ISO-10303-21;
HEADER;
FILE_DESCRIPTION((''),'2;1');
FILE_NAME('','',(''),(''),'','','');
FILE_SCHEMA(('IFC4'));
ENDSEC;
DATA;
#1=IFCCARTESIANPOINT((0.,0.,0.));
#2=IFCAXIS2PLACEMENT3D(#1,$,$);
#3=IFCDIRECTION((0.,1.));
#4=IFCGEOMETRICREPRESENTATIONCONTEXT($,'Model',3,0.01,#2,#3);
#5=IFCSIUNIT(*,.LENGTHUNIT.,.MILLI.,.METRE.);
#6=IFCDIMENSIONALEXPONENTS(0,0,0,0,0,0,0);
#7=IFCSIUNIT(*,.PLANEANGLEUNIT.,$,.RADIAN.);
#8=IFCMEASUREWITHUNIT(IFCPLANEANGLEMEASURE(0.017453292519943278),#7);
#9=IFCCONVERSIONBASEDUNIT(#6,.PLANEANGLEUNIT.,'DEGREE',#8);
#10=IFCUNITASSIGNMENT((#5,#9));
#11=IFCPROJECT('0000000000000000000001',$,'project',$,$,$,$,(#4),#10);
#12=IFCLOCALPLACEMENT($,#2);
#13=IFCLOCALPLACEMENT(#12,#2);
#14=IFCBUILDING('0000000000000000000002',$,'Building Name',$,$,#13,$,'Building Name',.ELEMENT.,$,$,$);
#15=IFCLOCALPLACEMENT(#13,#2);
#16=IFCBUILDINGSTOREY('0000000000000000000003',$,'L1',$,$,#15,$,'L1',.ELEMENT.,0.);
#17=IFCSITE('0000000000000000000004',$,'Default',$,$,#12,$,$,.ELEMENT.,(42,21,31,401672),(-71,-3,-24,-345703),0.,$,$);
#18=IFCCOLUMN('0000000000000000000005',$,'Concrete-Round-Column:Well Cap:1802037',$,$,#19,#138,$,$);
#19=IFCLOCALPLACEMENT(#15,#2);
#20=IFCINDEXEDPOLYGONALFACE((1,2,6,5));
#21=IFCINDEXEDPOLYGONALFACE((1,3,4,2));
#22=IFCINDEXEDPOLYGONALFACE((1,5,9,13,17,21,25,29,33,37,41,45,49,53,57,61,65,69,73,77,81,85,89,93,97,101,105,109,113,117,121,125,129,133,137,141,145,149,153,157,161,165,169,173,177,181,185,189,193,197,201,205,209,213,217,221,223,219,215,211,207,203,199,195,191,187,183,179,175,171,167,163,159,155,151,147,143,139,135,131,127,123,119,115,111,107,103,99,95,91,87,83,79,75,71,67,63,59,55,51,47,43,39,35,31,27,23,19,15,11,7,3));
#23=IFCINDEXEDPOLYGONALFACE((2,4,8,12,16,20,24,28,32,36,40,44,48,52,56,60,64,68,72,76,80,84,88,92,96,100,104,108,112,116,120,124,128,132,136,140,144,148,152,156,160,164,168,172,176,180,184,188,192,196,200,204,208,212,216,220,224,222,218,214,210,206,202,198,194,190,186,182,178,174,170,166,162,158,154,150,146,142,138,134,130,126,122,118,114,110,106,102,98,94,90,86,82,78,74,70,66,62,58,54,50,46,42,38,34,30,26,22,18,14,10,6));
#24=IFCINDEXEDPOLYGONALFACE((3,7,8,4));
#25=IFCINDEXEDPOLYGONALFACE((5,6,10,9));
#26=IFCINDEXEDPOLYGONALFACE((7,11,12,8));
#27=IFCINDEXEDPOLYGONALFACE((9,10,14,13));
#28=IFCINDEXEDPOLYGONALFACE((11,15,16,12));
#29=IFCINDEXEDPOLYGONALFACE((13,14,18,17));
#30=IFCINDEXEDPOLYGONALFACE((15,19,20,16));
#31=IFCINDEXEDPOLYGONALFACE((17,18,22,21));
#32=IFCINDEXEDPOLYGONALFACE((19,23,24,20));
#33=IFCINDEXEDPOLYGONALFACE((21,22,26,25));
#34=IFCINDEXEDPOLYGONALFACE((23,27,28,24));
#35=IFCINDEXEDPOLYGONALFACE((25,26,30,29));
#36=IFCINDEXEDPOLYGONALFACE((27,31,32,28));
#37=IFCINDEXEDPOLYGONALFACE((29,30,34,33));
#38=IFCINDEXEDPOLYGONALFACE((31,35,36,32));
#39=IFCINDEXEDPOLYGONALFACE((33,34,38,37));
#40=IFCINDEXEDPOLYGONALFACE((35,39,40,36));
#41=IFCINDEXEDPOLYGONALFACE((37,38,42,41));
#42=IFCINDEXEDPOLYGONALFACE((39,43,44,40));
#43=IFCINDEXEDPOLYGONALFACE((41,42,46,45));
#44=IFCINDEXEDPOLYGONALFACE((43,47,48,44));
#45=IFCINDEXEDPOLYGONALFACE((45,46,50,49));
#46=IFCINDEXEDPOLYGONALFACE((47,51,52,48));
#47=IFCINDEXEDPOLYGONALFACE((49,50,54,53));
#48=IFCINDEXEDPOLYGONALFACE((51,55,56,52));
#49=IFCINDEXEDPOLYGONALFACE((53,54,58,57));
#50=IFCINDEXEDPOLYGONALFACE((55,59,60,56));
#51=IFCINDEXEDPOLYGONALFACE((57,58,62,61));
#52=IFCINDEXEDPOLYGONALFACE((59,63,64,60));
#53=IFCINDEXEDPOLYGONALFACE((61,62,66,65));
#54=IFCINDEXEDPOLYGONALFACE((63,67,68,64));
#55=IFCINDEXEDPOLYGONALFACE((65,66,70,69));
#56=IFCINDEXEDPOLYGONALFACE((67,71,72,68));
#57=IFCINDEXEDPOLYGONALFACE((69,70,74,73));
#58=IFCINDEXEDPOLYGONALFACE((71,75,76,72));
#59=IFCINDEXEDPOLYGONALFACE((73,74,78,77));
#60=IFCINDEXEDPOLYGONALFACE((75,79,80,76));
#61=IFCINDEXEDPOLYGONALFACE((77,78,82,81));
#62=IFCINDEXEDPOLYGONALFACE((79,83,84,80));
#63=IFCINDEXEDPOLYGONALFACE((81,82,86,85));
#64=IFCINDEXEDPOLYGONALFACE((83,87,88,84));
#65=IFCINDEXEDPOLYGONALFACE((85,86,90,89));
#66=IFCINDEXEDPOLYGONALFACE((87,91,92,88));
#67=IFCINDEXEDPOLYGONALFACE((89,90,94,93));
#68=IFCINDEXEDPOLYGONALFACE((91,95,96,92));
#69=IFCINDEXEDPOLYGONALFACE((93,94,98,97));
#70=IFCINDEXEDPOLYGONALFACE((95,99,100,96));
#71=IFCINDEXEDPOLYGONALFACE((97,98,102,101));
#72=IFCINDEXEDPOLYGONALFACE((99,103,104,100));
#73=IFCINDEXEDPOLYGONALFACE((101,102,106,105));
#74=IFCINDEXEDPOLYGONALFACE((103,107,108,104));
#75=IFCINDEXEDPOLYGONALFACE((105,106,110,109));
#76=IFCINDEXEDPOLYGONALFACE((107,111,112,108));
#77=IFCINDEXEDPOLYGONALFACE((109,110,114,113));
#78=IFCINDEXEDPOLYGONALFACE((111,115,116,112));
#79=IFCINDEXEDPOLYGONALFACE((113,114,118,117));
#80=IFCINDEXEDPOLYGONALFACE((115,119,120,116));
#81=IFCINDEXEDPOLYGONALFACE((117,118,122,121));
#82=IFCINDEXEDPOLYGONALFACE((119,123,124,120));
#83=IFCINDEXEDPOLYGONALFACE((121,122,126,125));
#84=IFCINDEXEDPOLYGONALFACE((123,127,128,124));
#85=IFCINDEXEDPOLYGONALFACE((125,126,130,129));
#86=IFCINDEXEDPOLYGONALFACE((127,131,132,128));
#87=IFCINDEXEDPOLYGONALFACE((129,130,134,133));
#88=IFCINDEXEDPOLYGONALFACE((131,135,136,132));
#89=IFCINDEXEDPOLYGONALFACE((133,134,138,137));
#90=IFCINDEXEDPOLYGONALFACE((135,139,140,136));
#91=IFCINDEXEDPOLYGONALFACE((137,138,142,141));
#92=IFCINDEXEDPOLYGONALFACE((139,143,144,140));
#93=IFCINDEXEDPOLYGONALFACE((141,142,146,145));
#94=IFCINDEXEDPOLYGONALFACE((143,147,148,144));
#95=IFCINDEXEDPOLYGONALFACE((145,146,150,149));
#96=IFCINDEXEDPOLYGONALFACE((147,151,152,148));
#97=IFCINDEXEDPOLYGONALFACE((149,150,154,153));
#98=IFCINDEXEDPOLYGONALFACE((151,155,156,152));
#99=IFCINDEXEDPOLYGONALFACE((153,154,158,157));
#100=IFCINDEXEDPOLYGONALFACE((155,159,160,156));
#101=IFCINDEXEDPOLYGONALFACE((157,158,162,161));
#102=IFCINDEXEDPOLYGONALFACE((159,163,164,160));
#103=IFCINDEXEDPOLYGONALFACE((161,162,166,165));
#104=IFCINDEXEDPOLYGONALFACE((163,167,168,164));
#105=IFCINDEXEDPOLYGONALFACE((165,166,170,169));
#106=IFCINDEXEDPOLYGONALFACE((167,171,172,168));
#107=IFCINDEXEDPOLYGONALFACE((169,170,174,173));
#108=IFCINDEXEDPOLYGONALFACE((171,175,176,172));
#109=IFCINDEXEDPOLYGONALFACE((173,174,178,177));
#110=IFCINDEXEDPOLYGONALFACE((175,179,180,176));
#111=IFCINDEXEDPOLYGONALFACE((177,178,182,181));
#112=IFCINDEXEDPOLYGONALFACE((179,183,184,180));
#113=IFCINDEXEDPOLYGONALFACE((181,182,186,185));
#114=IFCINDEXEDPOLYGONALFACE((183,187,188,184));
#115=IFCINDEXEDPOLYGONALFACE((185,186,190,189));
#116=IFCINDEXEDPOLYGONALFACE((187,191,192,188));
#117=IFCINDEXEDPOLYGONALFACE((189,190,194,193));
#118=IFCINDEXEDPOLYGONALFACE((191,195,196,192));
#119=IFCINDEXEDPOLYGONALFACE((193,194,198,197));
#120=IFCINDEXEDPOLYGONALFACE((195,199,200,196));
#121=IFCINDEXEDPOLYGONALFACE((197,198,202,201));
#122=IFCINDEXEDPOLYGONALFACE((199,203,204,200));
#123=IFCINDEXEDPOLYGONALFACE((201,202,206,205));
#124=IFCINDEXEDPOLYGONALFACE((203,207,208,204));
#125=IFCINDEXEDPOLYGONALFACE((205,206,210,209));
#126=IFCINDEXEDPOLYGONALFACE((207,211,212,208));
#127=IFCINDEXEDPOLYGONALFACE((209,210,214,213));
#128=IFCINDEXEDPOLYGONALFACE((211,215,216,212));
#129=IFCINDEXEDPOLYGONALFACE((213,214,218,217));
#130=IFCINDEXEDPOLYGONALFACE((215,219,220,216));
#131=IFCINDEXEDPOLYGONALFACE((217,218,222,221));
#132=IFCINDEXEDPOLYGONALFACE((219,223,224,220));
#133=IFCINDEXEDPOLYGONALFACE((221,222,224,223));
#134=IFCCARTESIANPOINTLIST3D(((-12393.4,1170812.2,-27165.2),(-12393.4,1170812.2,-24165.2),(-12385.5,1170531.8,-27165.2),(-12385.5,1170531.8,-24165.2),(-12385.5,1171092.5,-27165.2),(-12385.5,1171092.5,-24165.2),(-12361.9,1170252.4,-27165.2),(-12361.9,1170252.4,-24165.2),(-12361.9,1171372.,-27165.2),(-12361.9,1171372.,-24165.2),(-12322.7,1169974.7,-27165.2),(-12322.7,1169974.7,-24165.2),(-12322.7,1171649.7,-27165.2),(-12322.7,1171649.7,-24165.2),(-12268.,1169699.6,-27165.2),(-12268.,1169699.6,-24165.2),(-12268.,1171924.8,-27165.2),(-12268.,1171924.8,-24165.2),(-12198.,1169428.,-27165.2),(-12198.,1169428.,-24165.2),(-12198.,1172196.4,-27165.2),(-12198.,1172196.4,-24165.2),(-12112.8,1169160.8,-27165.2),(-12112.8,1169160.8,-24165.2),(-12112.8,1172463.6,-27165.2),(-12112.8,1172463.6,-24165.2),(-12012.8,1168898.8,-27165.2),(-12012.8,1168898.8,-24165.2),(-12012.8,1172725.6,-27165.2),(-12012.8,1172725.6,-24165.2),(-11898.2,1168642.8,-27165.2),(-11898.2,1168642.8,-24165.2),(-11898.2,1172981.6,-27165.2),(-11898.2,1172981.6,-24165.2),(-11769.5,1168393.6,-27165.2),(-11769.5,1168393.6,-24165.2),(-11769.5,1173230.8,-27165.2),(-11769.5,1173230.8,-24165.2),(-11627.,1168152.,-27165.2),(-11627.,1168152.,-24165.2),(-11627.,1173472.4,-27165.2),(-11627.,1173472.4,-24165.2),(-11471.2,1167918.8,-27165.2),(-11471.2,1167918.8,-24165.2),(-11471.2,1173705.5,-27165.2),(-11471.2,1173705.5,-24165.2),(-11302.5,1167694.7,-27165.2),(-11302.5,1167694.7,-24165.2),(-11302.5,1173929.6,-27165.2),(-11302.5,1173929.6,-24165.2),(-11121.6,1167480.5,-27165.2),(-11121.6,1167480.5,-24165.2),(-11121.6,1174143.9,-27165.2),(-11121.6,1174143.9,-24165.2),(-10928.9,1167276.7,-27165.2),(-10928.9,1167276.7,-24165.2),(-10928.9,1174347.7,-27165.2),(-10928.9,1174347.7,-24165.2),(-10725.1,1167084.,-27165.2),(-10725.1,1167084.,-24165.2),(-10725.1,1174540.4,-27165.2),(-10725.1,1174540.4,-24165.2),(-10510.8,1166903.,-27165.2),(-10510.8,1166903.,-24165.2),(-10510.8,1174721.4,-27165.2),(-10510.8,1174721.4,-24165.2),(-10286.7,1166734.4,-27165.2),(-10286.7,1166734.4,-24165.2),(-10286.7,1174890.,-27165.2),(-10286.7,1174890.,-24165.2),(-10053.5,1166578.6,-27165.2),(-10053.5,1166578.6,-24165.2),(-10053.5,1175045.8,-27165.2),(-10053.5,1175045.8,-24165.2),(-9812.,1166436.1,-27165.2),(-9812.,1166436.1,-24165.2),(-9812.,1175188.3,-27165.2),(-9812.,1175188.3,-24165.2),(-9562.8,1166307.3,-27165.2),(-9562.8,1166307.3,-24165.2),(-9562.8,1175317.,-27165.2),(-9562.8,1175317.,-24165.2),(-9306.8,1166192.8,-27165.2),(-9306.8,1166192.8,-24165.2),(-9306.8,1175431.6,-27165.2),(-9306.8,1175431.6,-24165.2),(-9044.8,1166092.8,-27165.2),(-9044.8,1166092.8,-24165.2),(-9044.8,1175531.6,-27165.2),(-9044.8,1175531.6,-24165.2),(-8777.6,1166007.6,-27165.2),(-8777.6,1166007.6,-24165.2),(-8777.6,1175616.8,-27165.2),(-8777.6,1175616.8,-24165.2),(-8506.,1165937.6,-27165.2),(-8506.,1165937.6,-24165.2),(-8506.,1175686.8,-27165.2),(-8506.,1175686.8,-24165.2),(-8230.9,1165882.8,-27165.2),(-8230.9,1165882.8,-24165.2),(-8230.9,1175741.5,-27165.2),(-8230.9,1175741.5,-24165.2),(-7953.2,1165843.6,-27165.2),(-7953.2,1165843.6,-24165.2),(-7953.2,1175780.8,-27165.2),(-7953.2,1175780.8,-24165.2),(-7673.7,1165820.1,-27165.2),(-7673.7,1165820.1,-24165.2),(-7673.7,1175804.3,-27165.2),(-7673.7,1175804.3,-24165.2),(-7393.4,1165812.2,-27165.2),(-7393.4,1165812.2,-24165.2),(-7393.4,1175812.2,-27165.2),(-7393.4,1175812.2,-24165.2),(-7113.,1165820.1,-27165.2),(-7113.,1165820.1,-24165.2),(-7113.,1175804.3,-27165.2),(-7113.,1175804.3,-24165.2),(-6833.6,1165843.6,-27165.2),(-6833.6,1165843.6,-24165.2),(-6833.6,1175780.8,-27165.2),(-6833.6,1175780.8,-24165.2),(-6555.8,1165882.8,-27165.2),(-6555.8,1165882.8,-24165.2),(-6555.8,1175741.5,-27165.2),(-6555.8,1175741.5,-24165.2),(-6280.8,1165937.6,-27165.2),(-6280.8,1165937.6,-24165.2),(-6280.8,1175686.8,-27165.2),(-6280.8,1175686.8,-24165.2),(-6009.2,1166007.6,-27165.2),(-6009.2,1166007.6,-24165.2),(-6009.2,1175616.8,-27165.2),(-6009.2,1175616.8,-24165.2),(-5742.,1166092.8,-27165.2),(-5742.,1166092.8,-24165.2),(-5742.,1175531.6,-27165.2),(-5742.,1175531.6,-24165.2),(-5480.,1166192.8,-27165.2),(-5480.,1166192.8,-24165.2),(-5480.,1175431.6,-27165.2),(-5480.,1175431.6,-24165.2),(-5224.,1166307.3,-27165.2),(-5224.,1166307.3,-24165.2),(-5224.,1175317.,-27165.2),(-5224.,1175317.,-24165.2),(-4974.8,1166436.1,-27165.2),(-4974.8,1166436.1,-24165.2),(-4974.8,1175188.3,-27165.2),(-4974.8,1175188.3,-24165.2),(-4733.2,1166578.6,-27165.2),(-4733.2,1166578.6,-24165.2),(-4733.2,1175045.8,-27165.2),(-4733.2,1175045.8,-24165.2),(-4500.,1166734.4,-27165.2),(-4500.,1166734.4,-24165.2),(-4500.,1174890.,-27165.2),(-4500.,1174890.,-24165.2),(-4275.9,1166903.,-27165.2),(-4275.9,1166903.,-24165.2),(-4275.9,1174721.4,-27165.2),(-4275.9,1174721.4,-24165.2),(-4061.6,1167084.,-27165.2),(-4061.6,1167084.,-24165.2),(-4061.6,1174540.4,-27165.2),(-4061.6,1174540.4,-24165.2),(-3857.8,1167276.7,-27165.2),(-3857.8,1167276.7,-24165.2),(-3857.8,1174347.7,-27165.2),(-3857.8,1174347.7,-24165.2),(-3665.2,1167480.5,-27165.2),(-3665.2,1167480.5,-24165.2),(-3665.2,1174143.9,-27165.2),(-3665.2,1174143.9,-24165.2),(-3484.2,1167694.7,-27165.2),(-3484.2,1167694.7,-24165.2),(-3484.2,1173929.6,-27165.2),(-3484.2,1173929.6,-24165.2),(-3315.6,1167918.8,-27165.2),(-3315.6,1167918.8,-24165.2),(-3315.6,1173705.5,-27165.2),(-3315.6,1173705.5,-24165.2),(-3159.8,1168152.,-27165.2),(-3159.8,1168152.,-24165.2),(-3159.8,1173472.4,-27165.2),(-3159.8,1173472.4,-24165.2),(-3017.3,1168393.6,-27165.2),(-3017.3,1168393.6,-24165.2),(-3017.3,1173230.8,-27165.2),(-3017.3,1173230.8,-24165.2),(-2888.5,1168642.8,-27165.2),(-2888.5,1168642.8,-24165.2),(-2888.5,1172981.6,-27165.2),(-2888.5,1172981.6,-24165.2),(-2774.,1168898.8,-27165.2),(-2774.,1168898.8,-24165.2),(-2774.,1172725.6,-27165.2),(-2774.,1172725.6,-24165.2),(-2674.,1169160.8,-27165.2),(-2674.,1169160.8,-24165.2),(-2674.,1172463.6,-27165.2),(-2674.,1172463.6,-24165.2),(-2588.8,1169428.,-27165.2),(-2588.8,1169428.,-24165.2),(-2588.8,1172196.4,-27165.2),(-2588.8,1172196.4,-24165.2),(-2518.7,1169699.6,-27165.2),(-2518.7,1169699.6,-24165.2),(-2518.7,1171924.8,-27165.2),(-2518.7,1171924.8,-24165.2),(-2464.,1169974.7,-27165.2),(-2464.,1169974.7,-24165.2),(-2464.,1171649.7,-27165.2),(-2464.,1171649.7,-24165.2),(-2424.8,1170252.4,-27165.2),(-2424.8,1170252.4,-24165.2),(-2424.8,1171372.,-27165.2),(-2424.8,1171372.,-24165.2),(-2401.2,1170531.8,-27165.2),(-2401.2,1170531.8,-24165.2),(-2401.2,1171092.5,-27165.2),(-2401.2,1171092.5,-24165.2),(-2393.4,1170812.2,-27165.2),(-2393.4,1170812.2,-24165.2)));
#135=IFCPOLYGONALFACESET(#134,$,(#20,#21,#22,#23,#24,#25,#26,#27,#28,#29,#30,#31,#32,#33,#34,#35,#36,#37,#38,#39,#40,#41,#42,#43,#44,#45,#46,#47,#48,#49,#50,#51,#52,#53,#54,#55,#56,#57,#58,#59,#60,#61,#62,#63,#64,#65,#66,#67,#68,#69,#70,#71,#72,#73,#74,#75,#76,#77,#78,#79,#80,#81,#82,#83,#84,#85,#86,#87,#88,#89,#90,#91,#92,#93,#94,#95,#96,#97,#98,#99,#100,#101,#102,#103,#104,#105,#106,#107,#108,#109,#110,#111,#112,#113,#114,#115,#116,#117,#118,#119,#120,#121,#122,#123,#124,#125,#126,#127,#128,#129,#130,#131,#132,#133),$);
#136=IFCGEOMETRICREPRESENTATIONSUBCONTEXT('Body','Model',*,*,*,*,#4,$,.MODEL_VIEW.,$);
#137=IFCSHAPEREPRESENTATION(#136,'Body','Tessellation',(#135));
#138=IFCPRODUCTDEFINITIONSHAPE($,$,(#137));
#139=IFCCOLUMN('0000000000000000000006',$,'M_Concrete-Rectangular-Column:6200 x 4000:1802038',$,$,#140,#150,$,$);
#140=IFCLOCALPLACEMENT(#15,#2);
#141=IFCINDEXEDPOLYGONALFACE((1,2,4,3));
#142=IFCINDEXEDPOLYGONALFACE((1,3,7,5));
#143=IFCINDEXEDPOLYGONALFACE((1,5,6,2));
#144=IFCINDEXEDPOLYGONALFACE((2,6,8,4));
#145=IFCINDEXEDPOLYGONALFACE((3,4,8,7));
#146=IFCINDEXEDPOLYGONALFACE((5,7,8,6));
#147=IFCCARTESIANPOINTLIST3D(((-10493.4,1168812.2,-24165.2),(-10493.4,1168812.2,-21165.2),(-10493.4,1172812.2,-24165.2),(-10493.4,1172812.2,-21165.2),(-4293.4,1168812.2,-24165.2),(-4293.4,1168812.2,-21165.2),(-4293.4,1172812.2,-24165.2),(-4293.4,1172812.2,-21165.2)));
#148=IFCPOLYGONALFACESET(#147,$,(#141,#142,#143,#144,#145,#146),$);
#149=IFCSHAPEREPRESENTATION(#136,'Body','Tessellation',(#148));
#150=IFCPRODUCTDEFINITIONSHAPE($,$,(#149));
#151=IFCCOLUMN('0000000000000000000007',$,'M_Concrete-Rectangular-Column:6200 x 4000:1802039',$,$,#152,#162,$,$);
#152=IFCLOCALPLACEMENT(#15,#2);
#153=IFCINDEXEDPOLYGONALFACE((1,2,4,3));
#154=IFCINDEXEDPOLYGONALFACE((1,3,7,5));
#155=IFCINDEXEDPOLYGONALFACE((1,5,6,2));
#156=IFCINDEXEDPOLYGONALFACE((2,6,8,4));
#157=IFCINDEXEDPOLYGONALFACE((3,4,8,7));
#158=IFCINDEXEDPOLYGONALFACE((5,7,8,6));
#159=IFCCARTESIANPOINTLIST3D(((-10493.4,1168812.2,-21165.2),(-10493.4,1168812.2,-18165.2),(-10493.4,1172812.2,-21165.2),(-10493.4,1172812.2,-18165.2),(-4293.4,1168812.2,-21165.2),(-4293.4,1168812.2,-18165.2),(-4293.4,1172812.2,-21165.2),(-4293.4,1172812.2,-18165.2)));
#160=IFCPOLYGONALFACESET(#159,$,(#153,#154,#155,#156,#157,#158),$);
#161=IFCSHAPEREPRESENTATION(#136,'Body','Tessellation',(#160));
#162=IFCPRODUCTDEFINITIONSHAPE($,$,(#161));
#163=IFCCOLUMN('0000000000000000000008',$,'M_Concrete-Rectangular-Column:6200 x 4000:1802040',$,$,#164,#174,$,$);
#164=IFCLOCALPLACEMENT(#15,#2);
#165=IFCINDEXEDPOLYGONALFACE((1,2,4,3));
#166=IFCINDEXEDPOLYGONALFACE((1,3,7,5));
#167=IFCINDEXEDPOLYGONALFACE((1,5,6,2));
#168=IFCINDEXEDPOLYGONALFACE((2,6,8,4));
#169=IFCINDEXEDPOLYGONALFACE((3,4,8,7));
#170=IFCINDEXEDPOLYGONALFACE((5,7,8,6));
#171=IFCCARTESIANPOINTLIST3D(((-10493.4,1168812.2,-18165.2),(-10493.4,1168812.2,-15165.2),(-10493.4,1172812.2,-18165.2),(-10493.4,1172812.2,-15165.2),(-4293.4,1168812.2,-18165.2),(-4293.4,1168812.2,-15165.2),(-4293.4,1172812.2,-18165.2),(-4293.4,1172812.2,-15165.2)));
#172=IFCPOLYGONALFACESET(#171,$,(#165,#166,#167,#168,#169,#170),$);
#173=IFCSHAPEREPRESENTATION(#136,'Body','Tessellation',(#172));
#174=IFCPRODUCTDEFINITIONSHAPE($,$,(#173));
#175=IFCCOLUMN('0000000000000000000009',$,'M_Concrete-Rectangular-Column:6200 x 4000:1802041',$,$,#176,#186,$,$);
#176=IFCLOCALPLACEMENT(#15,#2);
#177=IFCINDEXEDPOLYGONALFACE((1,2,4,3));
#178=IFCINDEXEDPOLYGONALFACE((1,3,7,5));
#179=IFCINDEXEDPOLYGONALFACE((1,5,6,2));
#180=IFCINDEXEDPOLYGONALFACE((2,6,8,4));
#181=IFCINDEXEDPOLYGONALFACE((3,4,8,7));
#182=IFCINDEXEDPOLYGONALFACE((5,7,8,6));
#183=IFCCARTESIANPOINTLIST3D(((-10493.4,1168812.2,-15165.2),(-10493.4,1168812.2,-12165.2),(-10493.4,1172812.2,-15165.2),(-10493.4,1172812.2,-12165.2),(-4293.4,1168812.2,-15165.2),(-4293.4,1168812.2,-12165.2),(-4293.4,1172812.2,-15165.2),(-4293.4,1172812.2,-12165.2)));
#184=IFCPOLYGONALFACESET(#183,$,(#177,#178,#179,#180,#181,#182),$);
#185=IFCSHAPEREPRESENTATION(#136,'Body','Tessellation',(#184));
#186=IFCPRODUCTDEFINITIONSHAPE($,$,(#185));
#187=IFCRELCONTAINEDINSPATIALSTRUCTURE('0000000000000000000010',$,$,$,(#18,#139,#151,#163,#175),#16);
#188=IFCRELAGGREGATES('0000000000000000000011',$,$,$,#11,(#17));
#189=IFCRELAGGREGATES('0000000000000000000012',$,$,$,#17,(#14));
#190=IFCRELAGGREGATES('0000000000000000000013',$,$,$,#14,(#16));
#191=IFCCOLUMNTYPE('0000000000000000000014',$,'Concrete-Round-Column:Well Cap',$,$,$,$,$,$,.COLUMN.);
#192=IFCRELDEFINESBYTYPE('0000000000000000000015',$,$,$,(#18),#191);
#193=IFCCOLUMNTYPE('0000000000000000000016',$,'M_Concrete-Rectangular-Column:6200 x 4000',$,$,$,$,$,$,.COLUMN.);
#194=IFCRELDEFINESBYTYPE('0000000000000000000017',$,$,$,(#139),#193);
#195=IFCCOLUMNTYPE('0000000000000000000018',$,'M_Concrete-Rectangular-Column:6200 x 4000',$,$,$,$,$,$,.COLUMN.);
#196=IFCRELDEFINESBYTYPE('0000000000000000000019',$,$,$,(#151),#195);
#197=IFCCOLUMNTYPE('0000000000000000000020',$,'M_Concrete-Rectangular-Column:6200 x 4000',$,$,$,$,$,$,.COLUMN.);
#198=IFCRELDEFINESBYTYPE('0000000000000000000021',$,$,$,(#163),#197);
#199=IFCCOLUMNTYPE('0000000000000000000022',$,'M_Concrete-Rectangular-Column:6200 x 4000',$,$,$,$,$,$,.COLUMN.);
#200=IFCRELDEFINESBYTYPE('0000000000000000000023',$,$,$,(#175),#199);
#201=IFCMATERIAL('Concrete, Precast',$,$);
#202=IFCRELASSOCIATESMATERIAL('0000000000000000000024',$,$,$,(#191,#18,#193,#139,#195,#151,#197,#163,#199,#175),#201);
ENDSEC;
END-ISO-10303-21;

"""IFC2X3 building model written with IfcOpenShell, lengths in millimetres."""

from ifc_helpers import new_model, entity, si_unit, converted_unit, direction, frame, frame_2d, origin, place, context, subcontext, project, spatial, rectangle, circle, extrude, source, transform, mapped, material, type_object, type_shapes, element, save


model = new_model("IFC2X3")

# Units and contexts
model_context = context("Model", 3, precision=0.01, world=origin(), true_north=direction((0.0, 1.0)))
body_context = subcontext(model_context, "Body", "Model", "MODEL_VIEW")
ifc_project = project(units=[si_unit("LENGTHUNIT", "METRE", prefix="MILLI"), converted_unit("PLANEANGLEUNIT", "DEGREE", entity("IfcPlaneAngleMeasure", 0.017453292519943278), si_unit("PLANEANGLEUNIT", "RADIAN"), dimensions=[0, 0, 0, 0, 0, 0, 0])], contexts=[model_context])

# Site, building, storey
site_placement = place(None, origin())
site = spatial("IfcSite", under=ifc_project, at=site_placement, Name="Default", CompositionType="ELEMENT", RefLatitude=(42, 21, 31, 401672), RefLongitude=(-71, -3, -24, -345703), RefElevation=0.0)
building_placement = place(site_placement, origin())
building = spatial("IfcBuilding", under=site, at=building_placement, Name="Building Name", LongName="Building Name", CompositionType="ELEMENT")
storey_placement = place(building_placement, origin())
storey = spatial("IfcBuildingStorey", under=building, at=storey_placement, Name="L1", LongName="L1", CompositionType="ELEMENT", Elevation=0.0)

# Columns
ifc_material_1 = material(Name="Concrete, Precast")
column_type_1 = type_object("IfcColumnType", Name="Concrete-Round-Column:Well Cap", PredefinedType="COLUMN", material=ifc_material_1)
shared_shape_1 = source(origin(), body_context, "Body", "SweptSolid", [
    extrude(circle(Radius=5000.0, at=frame_2d((0.0, 0.0), x_axis=(1.0, 0.0))), frame((-7393.4, 1170812.2, -27165.2)), (0.0, 0.0, 1.0), 3000.0),
])
type_shapes(column_type_1, [shared_shape_1])
column_1_placement = place(storey_placement, origin())
element("IfcColumn", 1, at=column_1_placement, inside=storey, type_object=column_type_1, material=ifc_material_1, Name="Concrete-Round-Column:Well Cap:1802037", context=body_context, shape_type="MappedRepresentation", body=[
    mapped(shared_shape_1, transform((0.0, 0.0, 0.0), scale=1.0)),
])
column_type_2 = type_object("IfcColumnType", Name="M_Concrete-Rectangular-Column:6200 x 4000", PredefinedType="COLUMN", material=ifc_material_1)
shared_shape_2 = source(origin(), body_context, "Body", "SweptSolid", [
    extrude(rectangle(XDim=4000.0, YDim=6200.0, at=frame_2d((0.0, 0.0), x_axis=(1.0, 0.0))), frame((-7393.4, 1170812.2, -24165.2), z_axis=(0.0, 0.0, 1.0), x_axis=(0.0, -1.0, 0.0)), (0.0, 0.0, 1.0), 3000.0),
])
type_shapes(column_type_2, [shared_shape_2])
column_2_placement = place(storey_placement, origin())
element("IfcColumn", 2, at=column_2_placement, inside=storey, type_object=column_type_2, material=ifc_material_1, Name="M_Concrete-Rectangular-Column:6200 x 4000:1802038", context=body_context, shape_type="MappedRepresentation", body=[
    mapped(shared_shape_2, transform((0.0, 0.0, 0.0), scale=1.0)),
])
column_type_3 = type_object("IfcColumnType", Name="M_Concrete-Rectangular-Column:6200 x 4000", PredefinedType="COLUMN", material=ifc_material_1)
shared_shape_3 = source(origin(), body_context, "Body", "SweptSolid", [
    extrude(rectangle(XDim=4000.0, YDim=6200.0, at=frame_2d((0.0, 0.0), x_axis=(1.0, 0.0))), frame((-7393.4, 1170812.2, -21165.2), z_axis=(0.0, 0.0, 1.0), x_axis=(0.0, -1.0, 0.0)), (0.0, 0.0, 1.0), 3000.0),
])
type_shapes(column_type_3, [shared_shape_3])
column_3_placement = place(storey_placement, origin())
element("IfcColumn", 3, at=column_3_placement, inside=storey, type_object=column_type_3, material=ifc_material_1, Name="M_Concrete-Rectangular-Column:6200 x 4000:1802039", context=body_context, shape_type="MappedRepresentation", body=[
    mapped(shared_shape_3, transform((0.0, 0.0, 0.0), scale=1.0)),
])
column_type_4 = type_object("IfcColumnType", Name="M_Concrete-Rectangular-Column:6200 x 4000", PredefinedType="COLUMN", material=ifc_material_1)
shared_shape_4 = source(origin(), body_context, "Body", "SweptSolid", [
    extrude(rectangle(XDim=4000.0, YDim=6200.0, at=frame_2d((0.0, 0.0), x_axis=(1.0, 0.0))), frame((-7393.4, 1170812.2, -18165.2), z_axis=(0.0, 0.0, 1.0), x_axis=(0.0, -1.0, 0.0)), (0.0, 0.0, 1.0), 3000.0),
])
type_shapes(column_type_4, [shared_shape_4])
column_4_placement = place(storey_placement, origin())
element("IfcColumn", 4, at=column_4_placement, inside=storey, type_object=column_type_4, material=ifc_material_1, Name="M_Concrete-Rectangular-Column:6200 x 4000:1802040", context=body_context, shape_type="MappedRepresentation", body=[
    mapped(shared_shape_4, transform((0.0, 0.0, 0.0), scale=1.0)),
])
column_type_5 = type_object("IfcColumnType", Name="M_Concrete-Rectangular-Column:6200 x 4000", PredefinedType="COLUMN", material=ifc_material_1)
shared_shape_5 = source(origin(), body_context, "Body", "SweptSolid", [
    extrude(rectangle(XDim=4000.0, YDim=6200.0, at=frame_2d((0.0, 0.0), x_axis=(1.0, 0.0))), frame((-7393.4, 1170812.2, -15165.2), z_axis=(0.0, 0.0, 1.0), x_axis=(0.0, -1.0, 0.0)), (0.0, 0.0, 1.0), 3000.0),
])
type_shapes(column_type_5, [shared_shape_5])
column_5_placement = place(storey_placement, origin())
element("IfcColumn", 5, at=column_5_placement, inside=storey, type_object=column_type_5, material=ifc_material_1, Name="M_Concrete-Rectangular-Column:6200 x 4000:1802041", context=body_context, shape_type="MappedRepresentation", body=[
    mapped(shared_shape_5, transform((0.0, 0.0, 0.0), scale=1.0)),
])

save(model, "model.ifc")
